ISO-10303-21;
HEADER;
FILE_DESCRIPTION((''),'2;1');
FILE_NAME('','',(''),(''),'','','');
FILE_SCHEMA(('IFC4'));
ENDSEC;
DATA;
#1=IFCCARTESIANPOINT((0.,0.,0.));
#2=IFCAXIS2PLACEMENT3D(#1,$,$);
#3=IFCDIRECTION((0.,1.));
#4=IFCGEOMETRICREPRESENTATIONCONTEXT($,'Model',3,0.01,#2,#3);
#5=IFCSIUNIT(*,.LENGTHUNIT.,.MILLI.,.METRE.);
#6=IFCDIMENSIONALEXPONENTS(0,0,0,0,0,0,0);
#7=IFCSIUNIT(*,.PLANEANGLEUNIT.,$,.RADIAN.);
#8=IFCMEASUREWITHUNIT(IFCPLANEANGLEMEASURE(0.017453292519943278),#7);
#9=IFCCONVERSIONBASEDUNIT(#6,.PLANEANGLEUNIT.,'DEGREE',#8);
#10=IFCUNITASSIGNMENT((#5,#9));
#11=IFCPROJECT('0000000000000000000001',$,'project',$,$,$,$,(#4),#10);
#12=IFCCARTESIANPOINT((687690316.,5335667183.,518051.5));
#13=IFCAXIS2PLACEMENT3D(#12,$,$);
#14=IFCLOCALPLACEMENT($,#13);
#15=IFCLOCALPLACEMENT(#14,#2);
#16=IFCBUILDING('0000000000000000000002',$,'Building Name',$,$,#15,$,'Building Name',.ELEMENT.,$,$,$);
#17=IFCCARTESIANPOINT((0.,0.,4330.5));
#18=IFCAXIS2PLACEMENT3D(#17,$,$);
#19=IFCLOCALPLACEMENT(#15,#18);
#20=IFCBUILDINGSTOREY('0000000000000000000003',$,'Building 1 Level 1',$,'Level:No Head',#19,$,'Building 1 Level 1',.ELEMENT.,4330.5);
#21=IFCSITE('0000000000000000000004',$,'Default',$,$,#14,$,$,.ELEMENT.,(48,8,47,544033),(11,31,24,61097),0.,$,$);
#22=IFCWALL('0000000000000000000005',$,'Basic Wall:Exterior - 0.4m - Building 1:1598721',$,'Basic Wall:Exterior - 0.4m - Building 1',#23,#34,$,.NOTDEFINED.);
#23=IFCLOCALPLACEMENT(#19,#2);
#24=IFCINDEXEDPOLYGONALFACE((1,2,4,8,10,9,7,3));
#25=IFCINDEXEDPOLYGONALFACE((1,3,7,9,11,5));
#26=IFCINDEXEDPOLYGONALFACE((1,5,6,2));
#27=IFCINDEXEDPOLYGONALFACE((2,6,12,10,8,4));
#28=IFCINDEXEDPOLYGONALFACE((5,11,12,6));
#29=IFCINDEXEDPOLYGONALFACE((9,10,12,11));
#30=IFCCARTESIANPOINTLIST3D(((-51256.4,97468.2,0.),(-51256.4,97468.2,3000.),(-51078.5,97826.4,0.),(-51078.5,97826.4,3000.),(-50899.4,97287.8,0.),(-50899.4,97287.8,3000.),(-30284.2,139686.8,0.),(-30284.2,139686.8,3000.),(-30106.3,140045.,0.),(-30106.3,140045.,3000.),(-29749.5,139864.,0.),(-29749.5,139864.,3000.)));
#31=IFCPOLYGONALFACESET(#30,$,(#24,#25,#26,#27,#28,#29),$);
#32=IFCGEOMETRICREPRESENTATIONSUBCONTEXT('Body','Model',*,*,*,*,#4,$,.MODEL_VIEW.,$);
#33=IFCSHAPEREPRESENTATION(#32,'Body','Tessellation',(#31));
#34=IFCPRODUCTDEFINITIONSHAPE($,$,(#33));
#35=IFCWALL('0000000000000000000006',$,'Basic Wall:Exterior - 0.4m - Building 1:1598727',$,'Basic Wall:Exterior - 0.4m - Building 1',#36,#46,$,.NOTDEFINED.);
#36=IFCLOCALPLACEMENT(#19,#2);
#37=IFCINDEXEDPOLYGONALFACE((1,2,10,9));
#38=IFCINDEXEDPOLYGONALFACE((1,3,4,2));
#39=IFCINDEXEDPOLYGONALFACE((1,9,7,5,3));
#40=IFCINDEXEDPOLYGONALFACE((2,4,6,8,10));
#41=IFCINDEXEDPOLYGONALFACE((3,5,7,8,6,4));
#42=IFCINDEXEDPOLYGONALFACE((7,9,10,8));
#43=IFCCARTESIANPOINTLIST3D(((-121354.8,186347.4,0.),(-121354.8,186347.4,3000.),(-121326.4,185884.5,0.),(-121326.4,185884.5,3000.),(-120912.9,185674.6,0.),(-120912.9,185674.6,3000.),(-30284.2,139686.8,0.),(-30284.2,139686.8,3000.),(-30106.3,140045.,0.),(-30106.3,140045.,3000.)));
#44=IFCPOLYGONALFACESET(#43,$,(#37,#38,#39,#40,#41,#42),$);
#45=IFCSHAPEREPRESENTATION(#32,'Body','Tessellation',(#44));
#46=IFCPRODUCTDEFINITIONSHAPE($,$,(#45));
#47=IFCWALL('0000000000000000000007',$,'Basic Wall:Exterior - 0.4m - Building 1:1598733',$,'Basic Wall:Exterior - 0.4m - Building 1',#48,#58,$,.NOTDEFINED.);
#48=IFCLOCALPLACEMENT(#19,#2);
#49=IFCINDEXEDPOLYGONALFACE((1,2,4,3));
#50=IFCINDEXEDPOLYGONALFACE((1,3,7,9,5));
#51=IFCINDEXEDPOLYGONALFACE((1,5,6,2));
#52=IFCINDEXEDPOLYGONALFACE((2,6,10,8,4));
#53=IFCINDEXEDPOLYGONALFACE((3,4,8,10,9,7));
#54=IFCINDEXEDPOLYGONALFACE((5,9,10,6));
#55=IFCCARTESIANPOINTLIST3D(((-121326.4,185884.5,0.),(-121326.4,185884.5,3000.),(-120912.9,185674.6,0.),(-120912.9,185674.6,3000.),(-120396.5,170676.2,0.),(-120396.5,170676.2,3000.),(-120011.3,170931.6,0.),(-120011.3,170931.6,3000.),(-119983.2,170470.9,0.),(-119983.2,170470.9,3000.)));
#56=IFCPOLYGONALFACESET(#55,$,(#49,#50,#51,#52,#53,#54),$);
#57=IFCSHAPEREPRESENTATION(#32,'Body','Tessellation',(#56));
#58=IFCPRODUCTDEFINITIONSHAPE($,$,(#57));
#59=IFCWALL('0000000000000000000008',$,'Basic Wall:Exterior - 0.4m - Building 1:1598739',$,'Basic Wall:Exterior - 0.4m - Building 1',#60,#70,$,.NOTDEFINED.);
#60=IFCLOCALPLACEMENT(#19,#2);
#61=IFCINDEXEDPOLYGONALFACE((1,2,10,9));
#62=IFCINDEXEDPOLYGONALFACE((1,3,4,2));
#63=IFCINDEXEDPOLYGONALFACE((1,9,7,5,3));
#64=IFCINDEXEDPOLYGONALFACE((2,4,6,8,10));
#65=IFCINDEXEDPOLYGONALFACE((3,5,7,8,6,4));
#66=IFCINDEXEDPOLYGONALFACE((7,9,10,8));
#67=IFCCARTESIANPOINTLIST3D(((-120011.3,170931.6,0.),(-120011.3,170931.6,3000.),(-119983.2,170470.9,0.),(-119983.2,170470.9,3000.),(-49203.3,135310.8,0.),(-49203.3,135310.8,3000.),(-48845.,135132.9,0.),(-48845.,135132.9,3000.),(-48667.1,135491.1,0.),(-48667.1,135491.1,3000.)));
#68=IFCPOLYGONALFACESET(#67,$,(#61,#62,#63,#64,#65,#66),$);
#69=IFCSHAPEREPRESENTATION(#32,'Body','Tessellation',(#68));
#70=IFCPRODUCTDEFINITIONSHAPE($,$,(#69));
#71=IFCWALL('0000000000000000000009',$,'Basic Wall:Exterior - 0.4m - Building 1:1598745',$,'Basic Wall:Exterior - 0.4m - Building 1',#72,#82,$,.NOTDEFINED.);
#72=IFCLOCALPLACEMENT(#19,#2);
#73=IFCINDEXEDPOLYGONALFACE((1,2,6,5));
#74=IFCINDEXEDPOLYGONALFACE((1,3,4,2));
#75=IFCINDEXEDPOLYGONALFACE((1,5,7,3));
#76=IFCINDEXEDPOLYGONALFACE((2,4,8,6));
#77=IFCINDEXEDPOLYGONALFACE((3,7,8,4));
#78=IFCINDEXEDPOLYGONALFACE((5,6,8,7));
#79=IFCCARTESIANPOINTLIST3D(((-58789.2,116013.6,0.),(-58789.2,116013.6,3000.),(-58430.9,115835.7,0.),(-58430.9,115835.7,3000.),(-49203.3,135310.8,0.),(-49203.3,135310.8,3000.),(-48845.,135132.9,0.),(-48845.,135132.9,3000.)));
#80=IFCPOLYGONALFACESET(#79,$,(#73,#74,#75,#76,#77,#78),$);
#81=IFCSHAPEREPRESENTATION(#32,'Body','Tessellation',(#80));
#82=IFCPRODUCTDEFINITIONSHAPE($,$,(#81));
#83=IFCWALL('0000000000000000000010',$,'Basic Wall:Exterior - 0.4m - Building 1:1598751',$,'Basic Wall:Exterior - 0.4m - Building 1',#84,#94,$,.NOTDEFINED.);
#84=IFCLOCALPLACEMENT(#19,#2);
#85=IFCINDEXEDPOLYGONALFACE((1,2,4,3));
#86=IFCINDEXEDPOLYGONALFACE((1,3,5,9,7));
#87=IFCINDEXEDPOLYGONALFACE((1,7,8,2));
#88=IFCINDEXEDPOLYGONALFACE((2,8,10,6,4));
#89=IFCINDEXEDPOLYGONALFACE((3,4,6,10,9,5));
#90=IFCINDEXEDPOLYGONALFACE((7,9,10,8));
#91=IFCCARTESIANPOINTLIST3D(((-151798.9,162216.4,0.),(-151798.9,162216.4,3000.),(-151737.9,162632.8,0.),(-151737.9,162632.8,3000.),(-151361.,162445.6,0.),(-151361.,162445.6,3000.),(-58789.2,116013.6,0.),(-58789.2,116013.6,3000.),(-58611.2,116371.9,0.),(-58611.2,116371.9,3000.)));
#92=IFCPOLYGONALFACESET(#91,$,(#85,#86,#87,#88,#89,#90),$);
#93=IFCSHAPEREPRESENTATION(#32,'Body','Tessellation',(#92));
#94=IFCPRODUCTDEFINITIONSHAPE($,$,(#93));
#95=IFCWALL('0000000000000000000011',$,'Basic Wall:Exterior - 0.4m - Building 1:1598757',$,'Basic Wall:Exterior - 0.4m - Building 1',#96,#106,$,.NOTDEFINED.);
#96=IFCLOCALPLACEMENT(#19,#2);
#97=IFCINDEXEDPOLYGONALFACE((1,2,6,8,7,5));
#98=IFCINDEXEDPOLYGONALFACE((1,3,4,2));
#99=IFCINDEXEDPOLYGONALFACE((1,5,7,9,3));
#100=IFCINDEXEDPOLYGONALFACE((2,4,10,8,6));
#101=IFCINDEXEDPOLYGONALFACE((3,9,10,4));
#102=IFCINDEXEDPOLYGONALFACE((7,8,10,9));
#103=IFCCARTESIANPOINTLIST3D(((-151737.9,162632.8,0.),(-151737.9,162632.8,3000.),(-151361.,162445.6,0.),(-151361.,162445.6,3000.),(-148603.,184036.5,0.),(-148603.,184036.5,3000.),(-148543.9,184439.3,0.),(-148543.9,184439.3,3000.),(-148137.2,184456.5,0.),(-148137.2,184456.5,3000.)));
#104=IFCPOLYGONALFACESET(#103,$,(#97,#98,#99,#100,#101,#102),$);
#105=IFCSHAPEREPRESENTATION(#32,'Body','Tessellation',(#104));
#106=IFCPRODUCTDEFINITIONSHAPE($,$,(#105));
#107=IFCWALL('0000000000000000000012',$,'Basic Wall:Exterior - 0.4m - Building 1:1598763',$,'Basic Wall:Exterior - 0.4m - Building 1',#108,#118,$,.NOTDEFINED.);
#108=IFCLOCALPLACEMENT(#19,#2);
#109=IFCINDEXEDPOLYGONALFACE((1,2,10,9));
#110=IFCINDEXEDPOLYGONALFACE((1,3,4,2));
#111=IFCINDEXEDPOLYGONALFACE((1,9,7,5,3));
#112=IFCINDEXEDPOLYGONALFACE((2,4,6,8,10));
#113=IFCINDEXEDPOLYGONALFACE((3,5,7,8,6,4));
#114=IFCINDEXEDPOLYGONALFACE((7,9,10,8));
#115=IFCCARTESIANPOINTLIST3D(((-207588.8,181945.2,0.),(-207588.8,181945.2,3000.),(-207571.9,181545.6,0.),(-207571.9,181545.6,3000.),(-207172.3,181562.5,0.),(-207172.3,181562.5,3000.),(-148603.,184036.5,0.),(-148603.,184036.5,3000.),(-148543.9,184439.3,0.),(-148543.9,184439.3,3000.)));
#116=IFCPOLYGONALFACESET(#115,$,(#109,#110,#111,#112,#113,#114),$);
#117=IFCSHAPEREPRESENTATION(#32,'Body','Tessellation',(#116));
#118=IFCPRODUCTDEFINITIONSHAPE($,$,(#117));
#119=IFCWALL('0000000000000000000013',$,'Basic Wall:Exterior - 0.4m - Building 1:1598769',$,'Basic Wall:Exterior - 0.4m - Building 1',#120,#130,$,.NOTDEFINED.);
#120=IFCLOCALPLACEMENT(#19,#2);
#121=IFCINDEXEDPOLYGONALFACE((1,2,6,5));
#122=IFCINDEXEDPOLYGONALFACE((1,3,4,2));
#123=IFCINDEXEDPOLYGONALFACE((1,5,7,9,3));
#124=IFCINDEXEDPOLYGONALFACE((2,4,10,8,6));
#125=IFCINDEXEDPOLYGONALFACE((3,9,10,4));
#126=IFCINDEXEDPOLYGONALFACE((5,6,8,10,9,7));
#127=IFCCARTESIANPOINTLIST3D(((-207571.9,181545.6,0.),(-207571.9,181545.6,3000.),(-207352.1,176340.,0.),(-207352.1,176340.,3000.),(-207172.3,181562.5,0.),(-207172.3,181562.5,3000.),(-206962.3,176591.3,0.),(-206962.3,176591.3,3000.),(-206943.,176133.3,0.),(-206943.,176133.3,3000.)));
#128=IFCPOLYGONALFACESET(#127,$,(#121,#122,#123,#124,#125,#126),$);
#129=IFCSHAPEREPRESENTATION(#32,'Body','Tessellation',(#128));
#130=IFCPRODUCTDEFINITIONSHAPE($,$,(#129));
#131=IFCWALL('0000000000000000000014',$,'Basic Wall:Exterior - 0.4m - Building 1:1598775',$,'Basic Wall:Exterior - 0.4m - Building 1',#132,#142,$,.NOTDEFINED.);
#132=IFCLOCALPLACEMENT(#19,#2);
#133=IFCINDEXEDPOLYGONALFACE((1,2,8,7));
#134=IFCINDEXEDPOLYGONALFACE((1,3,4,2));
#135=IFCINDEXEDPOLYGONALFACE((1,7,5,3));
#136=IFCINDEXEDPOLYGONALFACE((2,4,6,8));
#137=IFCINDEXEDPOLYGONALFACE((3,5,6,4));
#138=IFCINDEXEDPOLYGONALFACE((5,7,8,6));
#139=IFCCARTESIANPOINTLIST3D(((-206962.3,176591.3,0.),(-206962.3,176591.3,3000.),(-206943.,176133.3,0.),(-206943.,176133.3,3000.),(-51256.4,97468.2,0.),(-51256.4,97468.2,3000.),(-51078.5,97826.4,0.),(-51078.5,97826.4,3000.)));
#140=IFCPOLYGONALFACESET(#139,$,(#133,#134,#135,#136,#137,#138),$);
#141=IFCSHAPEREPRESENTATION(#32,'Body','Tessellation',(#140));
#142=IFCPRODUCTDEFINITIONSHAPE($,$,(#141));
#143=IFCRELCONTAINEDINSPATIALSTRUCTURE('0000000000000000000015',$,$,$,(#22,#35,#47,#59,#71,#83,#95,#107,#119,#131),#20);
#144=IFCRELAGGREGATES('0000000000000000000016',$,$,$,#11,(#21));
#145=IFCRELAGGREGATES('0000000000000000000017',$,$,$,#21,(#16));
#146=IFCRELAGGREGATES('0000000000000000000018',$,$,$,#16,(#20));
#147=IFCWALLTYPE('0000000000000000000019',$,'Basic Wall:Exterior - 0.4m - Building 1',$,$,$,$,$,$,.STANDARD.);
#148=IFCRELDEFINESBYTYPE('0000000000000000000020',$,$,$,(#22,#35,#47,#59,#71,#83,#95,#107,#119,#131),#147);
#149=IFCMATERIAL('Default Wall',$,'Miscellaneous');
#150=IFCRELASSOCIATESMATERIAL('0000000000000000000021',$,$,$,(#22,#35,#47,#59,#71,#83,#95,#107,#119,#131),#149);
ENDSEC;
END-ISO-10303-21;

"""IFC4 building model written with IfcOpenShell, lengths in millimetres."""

from ifc_helpers import new_model, entity, si_unit, converted_unit, direction, frame, origin, place, context, subcontext, project, spatial, indexed_curve, outline, extrude, material, type_object, element, save


model = new_model("IFC4")

# Units and contexts
model_context = context("Model", 3, precision=0.01, world=origin(), true_north=direction((0.0, 1.0)))
body_context = subcontext(model_context, "Body", "Model", "MODEL_VIEW")
ifc_project = project(units=[si_unit("LENGTHUNIT", "METRE", prefix="MILLI"), converted_unit("PLANEANGLEUNIT", "DEGREE", entity("IfcPlaneAngleMeasure", 0.017453292519943278), si_unit("PLANEANGLEUNIT", "RADIAN"), dimensions=[0, 0, 0, 0, 0, 0, 0])], contexts=[model_context])

# Site, building, storey
site_placement = place(None, frame((687690316.0, 5335667183.0, 518051.5)))
site = spatial("IfcSite", under=ifc_project, at=site_placement, Name="Default", CompositionType="ELEMENT", RefLatitude=(48, 8, 47, 544033), RefLongitude=(11, 31, 24, 61097), RefElevation=0.0)
building_placement = place(site_placement, origin())
building = spatial("IfcBuilding", under=site, at=building_placement, Name="Building Name", LongName="Building Name", CompositionType="ELEMENT")
storey_placement = place(building_placement, frame((0.0, 0.0, 4330.5)))
storey = spatial("IfcBuildingStorey", under=building, at=storey_placement, Name="Building 1 Level 1", ObjectType="Level:No Head", LongName="Building 1 Level 1", CompositionType="ELEMENT", Elevation=4330.5)

# Walls
ifc_material_1 = material(Name="Default Wall", Category="Miscellaneous")
wall_type = type_object("IfcWallType", Name="Basic Wall:Exterior - 0.4m - Building 1", PredefinedType="STANDARD")
wall_1_placement = place(storey_placement, frame((-51078.5, 97376.7, 0.0), z_axis=(0.0, 0.0, 1.0), x_axis=(0.444885, 0.895588, 0.0)))
element("IfcWall", 1, at=wall_1_placement, inside=storey, type_object=wall_type, material=ifc_material_1, Name="Basic Wall:Exterior - 0.4m - Building 1:1598721", ObjectType="Basic Wall:Exterior - 0.4m - Building 1", PredefinedType="NOTDEFINED", context=body_context, shape_type="SweptSolid", body=[
    extrude(outline(indexed_curve([(47540.0, -200.0), (47543.5, 200.0), (47143.4, 200.0), (402.7, 200.0), (2.7, 200.0), (0.0, -200.0), (47540.0, -200.0)], self_intersect=False)), origin(), (0.0, 0.0, 1.0), 3000.0),
])
wall_2_placement = place(storey_placement, frame((-30193.7, 139865.1, 0.0), z_axis=(0.0, 0.0, 1.0), x_axis=(-0.891761, 0.452507, 0.0)))
element("IfcWall", 2, at=wall_2_placement, inside=storey, type_object=wall_type, material=ifc_material_1, Name="Basic Wall:Exterior - 0.4m - Building 1:1598727", ObjectType="Basic Wall:Exterior - 0.4m - Building 1", PredefinedType="NOTDEFINED", context=body_context, shape_type="SweptSolid", body=[
    extrude(outline(indexed_curve([(102327.4, -200.0), (102092.7, 200.0), (101628.9, 200.0), (0.0, 200.0), (3.4, -200.0), (102327.4, -200.0)], self_intersect=False)), origin(), (0.0, 0.0, 1.0), 3000.0),
])
wall_3_placement = place(storey_placement, frame((-121126.8, 185896.7, 0.0), z_axis=(0.0, 0.0, 1.0), x_axis=(0.061037, -0.998136, 0.0)))
element("IfcWall", 3, at=wall_3_placement, inside=storey, type_object=wall_type, material=ifc_material_1, Name="Basic Wall:Exterior - 0.4m - Building 1:1598733", ObjectType="Basic Wall:Exterior - 0.4m - Building 1", PredefinedType="NOTDEFINED", context=body_context, shape_type="SweptSolid", body=[
    extrude(outline(indexed_curve([(15236.7, -200.0), (15466.8, 200.0), (15005.3, 200.0), (234.7, 200.0), (0.0, -200.0), (15236.7, -200.0)], self_intersect=False)), origin(), (0.0, 0.0, 1.0), 3000.0),
])
wall_4_placement = place(storey_placement, frame((-120100.3, 170752.4, 0.0), z_axis=(0.0, 0.0, 1.0), x_axis=(0.895588, -0.444885, 0.0)))
element("IfcWall", 4, at=wall_4_placement, inside=storey, type_object=wall_type, material=ifc_material_1, Name="Basic Wall:Exterior - 0.4m - Building 1:1598739", ObjectType="Basic Wall:Exterior - 0.4m - Building 1", PredefinedType="NOTDEFINED", context=body_context, shape_type="SweptSolid", body=[
    extrude(outline(indexed_curve([(79662.0, -200.0), (79662.0, 200.0), (0.0, 200.0), (230.2, -200.0), (79262.0, -200.0), (79662.0, -200.0)], self_intersect=False)), origin(), (0.0, 0.0, 1.0), 3000.0),
])
wall_5_placement = place(storey_placement, frame((-49024.1, 135221.9, 0.0), z_axis=(0.0, 0.0, 1.0), x_axis=(-0.444885, -0.895588, 0.0)))
element("IfcWall", 5, at=wall_5_placement, inside=storey, type_object=wall_type, material=ifc_material_1, Name="Basic Wall:Exterior - 0.4m - Building 1:1598745", ObjectType="Basic Wall:Exterior - 0.4m - Building 1", PredefinedType="NOTDEFINED", context=body_context, shape_type="SweptSolid", body=[
    extrude(outline(indexed_curve([(21547.0, 200.0), (0.0, 200.0), (0.0, -200.0), (21547.0, -200.0), (21547.0, 200.0)], self_intersect=False)), origin(), (0.0, 0.0, 1.0), 3000.0),
])
wall_6_placement = place(storey_placement, frame((-58700.2, 116192.8, 0.0), z_axis=(0.0, 0.0, 1.0), x_axis=(-0.895588, 0.444885, 0.0)))
element("IfcWall", 6, at=wall_6_placement, inside=storey, type_object=wall_type, material=ifc_material_1, Name="Basic Wall:Exterior - 0.4m - Building 1:1598751", ObjectType="Basic Wall:Exterior - 0.4m - Building 1", PredefinedType="NOTDEFINED", context=body_context, shape_type="SweptSolid", body=[
    extrude(outline(indexed_curve([(103983.9, -200.0), (103853.3, 200.0), (0.0, 200.0), (0.0, -200.0), (103563.1, -200.0), (103983.9, -200.0)], self_intersect=False)), origin(), (0.0, 0.0, 1.0), 3000.0),
])
wall_7_placement = place(storey_placement, frame((-151558.9, 162474.6, 0.0), z_axis=(0.0, 0.0, 1.0), x_axis=(0.144921, 0.989443, 0.0)))
element("IfcWall", 7, at=wall_7_placement, inside=storey, type_object=wall_type, material=ifc_material_1, Name="Basic Wall:Exterior - 0.4m - Building 1:1598757", ObjectType="Basic Wall:Exterior - 0.4m - Building 1", PredefinedType="NOTDEFINED", context=body_context, shape_type="SweptSolid", body=[
    extrude(outline(indexed_curve([(22245.8, -200.0), (22169.8, 200.0), (21762.7, 200.0), (130.6, 200.0), (0.0, -200.0), (22245.8, -200.0)], self_intersect=False)), origin(), (0.0, 0.0, 1.0), 3000.0),
])
wall_8_placement = place(storey_placement, frame((-148535.5, 184239.5, 0.0), z_axis=(0.0, 0.0, 1.0), x_axis=(-0.999109, -0.042203, 0.0)))
element("IfcWall", 8, at=wall_8_placement, inside=storey, type_object=wall_type, material=ifc_material_1, Name="Basic Wall:Exterior - 0.4m - Building 1:1598763", ObjectType="Basic Wall:Exterior - 0.4m - Building 1", PredefinedType="NOTDEFINED", context=body_context, shape_type="SweptSolid", body=[
    extrude(outline(indexed_curve([(59097.5, -200.0), (59097.5, 200.0), (58697.5, 200.0), (76.0, 200.0), (0.0, -200.0), (59097.5, -200.0)], self_intersect=False)), origin(), (0.0, 0.0, 1.0), 3000.0),
])
wall_9_placement = place(storey_placement, frame((-207372.1, 181554.0, 0.0), z_axis=(0.0, 0.0, 1.0), x_axis=(0.042203, -0.999109, 0.0)))
element("IfcWall", 9, at=wall_9_placement, inside=storey, type_object=wall_type, material=ifc_material_1, Name="Basic Wall:Exterior - 0.4m - Building 1:1598769", ObjectType="Basic Wall:Exterior - 0.4m - Building 1", PredefinedType="NOTDEFINED", context=body_context, shape_type="SweptSolid", body=[
    extrude(outline(indexed_curve([(5210.2, -200.0), (5434.0, 200.0), (4975.6, 200.0), (0.0, 200.0), (0.0, -200.0), (5210.2, -200.0)], self_intersect=False)), origin(), (0.0, 0.0, 1.0), 3000.0),
])
wall_10_placement = place(storey_placement, frame((-207052.5, 176412.8, 0.0), z_axis=(0.0, 0.0, 1.0), x_axis=(0.892534, -0.450979, 0.0)))
element("IfcWall", 10, at=wall_10_placement, inside=storey, type_object=wall_type, material=ifc_material_1, Name="Basic Wall:Exterior - 0.4m - Building 1:1598775", ObjectType="Basic Wall:Exterior - 0.4m - Building 1", PredefinedType="NOTDEFINED", context=body_context, shape_type="SweptSolid", body=[
    extrude(outline(indexed_curve([(174655.7, -200.0), (174653.0, 200.0), (0.0, 200.0), (223.8, -200.0), (174655.7, -200.0)], self_intersect=False)), origin(), (0.0, 0.0, 1.0), 3000.0),
])

save(model, "model.ifc")
